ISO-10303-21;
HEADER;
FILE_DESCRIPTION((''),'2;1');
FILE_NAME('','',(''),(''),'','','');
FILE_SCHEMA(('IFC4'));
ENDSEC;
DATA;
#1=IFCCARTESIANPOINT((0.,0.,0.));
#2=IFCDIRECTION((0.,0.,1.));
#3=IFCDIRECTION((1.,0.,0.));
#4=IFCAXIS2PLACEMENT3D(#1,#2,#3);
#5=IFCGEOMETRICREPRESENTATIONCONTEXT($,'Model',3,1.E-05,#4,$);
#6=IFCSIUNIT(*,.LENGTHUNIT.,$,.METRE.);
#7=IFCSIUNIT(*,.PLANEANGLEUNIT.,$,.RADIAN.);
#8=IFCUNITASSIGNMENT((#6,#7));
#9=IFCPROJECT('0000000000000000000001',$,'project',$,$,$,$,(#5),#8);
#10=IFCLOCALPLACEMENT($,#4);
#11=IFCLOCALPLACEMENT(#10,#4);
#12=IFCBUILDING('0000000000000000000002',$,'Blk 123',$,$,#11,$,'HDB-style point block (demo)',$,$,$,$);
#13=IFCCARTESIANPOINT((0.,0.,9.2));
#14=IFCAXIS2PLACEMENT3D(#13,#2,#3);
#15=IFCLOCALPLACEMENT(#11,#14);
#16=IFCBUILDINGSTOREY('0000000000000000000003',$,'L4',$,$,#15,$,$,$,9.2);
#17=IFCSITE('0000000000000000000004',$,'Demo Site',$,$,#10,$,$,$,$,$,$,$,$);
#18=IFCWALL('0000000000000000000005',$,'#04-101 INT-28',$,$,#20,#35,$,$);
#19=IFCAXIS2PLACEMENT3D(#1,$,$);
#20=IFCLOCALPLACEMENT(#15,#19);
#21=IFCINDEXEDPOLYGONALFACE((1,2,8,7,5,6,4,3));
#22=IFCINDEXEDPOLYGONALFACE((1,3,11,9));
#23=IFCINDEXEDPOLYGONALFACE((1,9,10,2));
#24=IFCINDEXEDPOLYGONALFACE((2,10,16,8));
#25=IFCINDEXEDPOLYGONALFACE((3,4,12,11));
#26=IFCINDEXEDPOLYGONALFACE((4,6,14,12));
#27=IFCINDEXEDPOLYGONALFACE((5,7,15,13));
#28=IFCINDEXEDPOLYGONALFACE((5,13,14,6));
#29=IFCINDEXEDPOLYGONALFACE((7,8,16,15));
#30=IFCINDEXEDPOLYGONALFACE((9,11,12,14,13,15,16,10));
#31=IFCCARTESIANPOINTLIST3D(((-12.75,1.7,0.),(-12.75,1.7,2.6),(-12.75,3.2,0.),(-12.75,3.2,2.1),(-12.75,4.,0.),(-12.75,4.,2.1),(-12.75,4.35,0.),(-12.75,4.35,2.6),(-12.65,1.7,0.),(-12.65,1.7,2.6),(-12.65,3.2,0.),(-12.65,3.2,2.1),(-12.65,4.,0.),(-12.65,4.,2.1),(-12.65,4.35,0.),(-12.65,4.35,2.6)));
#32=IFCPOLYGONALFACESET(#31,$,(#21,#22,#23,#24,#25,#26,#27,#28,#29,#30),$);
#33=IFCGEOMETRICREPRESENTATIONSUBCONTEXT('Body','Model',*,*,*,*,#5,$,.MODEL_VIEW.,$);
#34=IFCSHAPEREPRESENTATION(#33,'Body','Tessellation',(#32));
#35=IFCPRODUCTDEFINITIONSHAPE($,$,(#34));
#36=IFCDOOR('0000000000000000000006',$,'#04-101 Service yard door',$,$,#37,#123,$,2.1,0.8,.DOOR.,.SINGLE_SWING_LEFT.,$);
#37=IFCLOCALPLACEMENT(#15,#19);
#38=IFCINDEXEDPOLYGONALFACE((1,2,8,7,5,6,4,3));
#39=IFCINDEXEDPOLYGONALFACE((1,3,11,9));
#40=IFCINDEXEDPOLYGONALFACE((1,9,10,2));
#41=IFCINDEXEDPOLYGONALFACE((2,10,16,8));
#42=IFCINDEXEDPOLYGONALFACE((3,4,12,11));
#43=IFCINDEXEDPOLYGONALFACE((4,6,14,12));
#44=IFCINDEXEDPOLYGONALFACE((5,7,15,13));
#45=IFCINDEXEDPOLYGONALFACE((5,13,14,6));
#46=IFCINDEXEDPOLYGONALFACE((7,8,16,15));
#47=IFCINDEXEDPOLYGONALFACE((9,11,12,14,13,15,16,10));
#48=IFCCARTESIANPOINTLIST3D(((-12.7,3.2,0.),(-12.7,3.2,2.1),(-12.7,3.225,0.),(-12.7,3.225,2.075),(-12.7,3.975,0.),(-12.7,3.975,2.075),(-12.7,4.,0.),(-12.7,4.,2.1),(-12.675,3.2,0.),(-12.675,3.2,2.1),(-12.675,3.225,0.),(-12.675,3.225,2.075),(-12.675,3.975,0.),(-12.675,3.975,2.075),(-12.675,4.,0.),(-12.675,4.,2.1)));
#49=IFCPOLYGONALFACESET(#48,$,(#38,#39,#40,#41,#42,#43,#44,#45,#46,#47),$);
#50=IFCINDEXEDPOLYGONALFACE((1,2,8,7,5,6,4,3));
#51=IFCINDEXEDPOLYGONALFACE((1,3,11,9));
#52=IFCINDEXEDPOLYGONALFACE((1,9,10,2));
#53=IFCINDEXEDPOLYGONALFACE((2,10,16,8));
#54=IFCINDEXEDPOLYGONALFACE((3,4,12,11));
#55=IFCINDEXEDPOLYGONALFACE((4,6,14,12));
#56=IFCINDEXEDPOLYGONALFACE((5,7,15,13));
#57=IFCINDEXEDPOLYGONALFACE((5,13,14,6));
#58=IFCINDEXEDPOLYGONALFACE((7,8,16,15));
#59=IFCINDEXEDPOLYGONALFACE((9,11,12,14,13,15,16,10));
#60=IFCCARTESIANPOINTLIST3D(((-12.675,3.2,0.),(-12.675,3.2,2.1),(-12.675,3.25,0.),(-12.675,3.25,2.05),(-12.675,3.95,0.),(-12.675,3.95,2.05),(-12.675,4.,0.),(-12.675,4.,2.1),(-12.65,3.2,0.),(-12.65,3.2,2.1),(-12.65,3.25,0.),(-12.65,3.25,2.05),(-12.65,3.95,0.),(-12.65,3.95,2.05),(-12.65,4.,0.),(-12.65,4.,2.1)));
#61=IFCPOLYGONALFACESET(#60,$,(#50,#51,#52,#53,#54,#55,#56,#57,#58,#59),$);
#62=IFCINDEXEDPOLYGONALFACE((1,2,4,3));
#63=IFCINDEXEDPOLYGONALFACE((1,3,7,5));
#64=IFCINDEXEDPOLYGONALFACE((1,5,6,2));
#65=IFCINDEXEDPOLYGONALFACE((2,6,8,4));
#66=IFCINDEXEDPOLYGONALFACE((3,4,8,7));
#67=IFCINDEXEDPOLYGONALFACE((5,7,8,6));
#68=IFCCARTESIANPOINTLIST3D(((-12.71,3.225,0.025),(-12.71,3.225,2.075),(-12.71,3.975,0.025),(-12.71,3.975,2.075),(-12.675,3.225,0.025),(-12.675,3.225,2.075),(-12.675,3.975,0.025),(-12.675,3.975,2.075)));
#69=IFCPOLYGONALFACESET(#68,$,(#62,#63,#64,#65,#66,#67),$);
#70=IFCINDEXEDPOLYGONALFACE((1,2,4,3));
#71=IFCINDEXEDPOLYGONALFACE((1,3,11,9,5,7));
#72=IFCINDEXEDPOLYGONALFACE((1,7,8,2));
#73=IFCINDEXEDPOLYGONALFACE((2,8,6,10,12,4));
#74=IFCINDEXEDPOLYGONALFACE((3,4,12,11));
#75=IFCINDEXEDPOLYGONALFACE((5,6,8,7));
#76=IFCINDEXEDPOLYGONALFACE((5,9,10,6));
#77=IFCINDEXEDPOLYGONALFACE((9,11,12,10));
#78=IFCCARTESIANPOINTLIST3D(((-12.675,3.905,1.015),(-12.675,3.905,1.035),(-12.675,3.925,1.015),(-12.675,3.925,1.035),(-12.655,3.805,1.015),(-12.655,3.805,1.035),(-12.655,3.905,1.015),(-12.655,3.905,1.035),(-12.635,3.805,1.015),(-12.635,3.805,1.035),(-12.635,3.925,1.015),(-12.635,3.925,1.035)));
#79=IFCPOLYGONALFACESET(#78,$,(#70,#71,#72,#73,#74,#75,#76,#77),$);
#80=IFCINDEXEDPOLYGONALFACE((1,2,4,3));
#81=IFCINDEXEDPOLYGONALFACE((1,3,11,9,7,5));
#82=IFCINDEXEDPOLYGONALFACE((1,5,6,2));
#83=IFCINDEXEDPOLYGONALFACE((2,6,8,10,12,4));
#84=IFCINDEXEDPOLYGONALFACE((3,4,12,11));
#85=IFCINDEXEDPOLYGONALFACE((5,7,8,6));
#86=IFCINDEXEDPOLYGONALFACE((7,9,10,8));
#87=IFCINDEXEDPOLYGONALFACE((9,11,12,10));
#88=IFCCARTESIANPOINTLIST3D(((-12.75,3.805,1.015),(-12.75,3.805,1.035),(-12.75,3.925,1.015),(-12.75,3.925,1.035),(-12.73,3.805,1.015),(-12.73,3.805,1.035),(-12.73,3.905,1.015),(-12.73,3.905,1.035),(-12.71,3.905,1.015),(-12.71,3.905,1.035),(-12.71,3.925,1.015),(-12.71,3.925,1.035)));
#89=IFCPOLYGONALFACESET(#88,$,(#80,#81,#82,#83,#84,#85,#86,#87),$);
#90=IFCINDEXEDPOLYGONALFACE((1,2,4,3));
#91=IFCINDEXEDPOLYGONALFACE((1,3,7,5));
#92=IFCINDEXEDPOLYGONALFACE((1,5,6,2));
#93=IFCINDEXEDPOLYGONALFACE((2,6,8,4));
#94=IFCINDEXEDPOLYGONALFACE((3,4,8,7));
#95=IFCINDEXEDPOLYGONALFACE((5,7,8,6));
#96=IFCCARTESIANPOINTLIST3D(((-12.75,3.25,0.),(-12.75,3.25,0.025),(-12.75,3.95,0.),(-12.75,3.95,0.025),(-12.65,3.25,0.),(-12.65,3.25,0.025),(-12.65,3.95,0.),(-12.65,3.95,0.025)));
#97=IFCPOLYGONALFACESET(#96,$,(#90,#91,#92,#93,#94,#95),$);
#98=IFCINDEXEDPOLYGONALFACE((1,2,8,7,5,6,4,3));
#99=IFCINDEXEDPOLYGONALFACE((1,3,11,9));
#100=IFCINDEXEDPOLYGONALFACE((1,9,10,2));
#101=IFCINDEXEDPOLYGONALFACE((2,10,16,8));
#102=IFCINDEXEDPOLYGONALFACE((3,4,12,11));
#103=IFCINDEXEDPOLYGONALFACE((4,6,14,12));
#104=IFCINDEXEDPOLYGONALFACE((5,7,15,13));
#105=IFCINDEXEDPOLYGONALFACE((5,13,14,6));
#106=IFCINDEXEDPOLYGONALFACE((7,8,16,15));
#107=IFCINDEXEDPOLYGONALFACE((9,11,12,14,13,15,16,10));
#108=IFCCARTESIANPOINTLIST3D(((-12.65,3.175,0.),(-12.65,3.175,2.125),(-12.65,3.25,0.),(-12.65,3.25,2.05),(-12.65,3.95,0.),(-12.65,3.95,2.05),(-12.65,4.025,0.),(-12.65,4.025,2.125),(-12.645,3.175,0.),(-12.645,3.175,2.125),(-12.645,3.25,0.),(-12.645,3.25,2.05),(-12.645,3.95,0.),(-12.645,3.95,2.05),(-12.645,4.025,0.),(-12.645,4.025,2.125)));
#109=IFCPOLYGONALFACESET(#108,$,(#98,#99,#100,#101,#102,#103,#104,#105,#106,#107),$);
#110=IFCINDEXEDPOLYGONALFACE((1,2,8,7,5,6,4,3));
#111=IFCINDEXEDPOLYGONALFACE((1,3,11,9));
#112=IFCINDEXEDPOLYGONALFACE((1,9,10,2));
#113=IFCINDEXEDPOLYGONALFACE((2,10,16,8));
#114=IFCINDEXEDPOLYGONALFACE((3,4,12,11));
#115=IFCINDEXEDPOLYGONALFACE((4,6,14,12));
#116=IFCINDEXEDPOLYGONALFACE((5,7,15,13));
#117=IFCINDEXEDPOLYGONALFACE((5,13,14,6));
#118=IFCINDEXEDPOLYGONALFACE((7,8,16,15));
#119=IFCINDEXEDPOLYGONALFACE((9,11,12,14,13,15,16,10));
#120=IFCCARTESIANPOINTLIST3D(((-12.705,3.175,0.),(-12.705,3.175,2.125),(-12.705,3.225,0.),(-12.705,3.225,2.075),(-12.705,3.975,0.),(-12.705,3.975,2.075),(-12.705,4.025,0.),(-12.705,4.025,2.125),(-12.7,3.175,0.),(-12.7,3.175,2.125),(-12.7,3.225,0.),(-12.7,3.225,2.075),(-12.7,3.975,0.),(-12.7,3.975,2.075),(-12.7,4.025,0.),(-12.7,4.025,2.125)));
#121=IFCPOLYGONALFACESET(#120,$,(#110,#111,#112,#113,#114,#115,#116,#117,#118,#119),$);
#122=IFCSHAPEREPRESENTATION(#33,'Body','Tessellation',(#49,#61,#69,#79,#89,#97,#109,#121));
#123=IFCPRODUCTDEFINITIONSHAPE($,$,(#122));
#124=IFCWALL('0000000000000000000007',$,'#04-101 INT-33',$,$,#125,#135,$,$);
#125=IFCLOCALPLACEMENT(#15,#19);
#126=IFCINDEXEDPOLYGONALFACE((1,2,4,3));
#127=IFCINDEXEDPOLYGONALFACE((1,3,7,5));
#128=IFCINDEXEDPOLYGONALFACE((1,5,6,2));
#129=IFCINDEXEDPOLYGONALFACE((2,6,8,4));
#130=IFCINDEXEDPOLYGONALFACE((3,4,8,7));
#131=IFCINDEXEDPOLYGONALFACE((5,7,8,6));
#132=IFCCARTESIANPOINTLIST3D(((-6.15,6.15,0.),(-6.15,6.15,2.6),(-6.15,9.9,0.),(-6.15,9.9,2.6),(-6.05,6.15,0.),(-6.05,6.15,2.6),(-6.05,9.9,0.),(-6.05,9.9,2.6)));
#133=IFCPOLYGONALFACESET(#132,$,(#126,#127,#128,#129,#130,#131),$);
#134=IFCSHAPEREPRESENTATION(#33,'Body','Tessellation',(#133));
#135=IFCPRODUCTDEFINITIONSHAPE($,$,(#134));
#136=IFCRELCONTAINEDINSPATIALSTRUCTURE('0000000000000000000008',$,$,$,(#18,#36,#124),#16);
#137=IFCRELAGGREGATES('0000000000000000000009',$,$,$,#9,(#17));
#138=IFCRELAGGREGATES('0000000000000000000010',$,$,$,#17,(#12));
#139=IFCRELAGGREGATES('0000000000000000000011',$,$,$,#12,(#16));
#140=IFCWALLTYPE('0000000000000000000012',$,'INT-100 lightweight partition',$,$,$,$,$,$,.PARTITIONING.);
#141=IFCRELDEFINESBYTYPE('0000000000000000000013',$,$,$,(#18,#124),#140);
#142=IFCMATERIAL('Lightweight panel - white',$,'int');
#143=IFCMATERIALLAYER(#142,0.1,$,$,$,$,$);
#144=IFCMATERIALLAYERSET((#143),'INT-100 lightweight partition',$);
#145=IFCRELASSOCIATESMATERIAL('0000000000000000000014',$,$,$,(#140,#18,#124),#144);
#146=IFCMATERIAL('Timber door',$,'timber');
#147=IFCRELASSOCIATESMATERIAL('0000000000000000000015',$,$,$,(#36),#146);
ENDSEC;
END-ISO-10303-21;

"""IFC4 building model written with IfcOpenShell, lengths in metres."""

from ifc_helpers import new_model, si_unit, frame, origin_with_axes, place, context, subcontext, project, spatial, line, indexed_curve, outline, extrude, material, layer, layer_set, layer_usage, type_object, element, fill, save


model = new_model("IFC4")

# Units and contexts
model_context = context("Model", 3, precision=1e-05, world=origin_with_axes())
body_context = subcontext(model_context, "Body", "Model", "MODEL_VIEW")
ifc_project = project(units=[si_unit("LENGTHUNIT", "METRE"), si_unit("PLANEANGLEUNIT", "RADIAN")], contexts=[model_context])

# Site, building, storey
site_placement = place(None, origin_with_axes())
site = spatial("IfcSite", under=ifc_project, at=site_placement, Name="Demo Site")
building_placement = place(site_placement, origin_with_axes())
building = spatial("IfcBuilding", under=site, at=building_placement, Name="Blk 123", LongName="HDB-style point block (demo)")
storey_placement = place(building_placement, frame((0.0, 0.0, 9.2), z_axis=(0.0, 0.0, 1.0), x_axis=(1.0, 0.0, 0.0)))
storey = spatial("IfcBuildingStorey", under=building, at=storey_placement, Name="L4", Elevation=9.2)

# Shared definitions
ifc_material_1 = material(Name="Timber door", Category="timber")

# Shared definitions
ifc_material_2 = material(Name="Lightweight panel - white", Category="int")
ifc_layer_1 = layer(ifc_material_2, 0.1)
ifc_layer_set_1 = layer_set([ifc_layer_1], Name="INT-100 lightweight partition")
ifc_layer_usage_1 = layer_usage(ifc_layer_set_1, "AXIS2", "POSITIVE", -0.05)
wall_type_1 = type_object("IfcWallType", Name="INT-100 lightweight partition", PredefinedType="PARTITIONING", material=ifc_layer_set_1)

# Wall, opening, door
wall_1_placement = place(storey_placement, frame((-12.7, 1.7, 0.0), z_axis=(0.0, 0.0, 1.0), x_axis=(0.0, 1.0, 0.0)))
wall_1 = element("IfcWall", 1, at=wall_1_placement, inside=storey, type_object=wall_type_1, material=ifc_layer_usage_1, Name="#04-101 INT-28", context=body_context, shape_type="SweptSolid", body=[
    extrude(outline(indexed_curve([(0.0, 0.0), (0.0, 0.1), (2.65, 0.1), (2.65, 0.0), (0.0, 0.0)], self_intersect=False)), frame((0.0, -0.05, 0.0), z_axis=(0.0, 0.0, 1.0), x_axis=(1.0, 0.0, 0.0)), (0.0, 0.0, 1.0), 2.6),
])
opening_1_placement = place(wall_1_placement, frame((1.5, -0.15, 0.0), z_axis=(0.0, 0.0, 1.0), x_axis=(1.0, 0.0, 0.0)))
opening_1 = element("IfcOpeningElement", 2, at=opening_1_placement, cuts=wall_1, context=body_context, shape_type="SweptSolid", body=[
    extrude(outline(indexed_curve([(0.0, 0.0), (0.0, 0.3), (0.8, 0.3), (0.8, 0.0), (0.0, 0.0)], self_intersect=False)), origin_with_axes(), (0.0, 0.0, 1.0), 2.1),
])
door_1_placement = place(opening_1_placement, frame((0.0, 0.1, 0.0), z_axis=(0.0, 0.0, 1.0), x_axis=(1.0, 0.0, 0.0)))
door_1 = element("IfcDoor", 3, at=door_1_placement, inside=storey, material=ifc_material_1, Name="#04-101 Service yard door", OperationType="SINGLE_SWING_LEFT", OverallHeight=2.1, OverallWidth=0.8, PredefinedType="DOOR", context=body_context, shape_type="SweptSolid", body=[
    extrude(outline(indexed_curve([(0.0, 0.0), (0.0, 2.1), (0.8, 2.1), (0.8, 0.0), (0.775, 0.0), (0.775, 2.075), (0.025, 2.075), (0.025, 0.0)], segments=[line(1, 2, 3, 4, 5, 6, 7, 8, 1)])), frame((0.0, 0.025, 0.0), z_axis=(0.0, -1.0, 0.0), x_axis=(1.0, 0.0, 0.0)), (0.0, 0.0, -1.0), 0.025),
    extrude(outline(indexed_curve([(0.0, 0.0), (0.0, 2.1), (0.8, 2.1), (0.8, 0.0), (0.75, 0.0), (0.75, 2.05), (0.05, 2.05), (0.05, 0.0)], segments=[line(1, 2, 3, 4, 5, 6, 7, 8, 1)])), frame((0.0, 0.0, 0.0), z_axis=(0.0, -1.0, 0.0), x_axis=(1.0, 0.0, 0.0)), (0.0, 0.0, -1.0), 0.025),
    extrude(outline(indexed_curve([(0.0, 0.0), (0.75, 0.0), (0.75, 0.035), (0.0, 0.035)], segments=[line(1, 2, 3, 4, 1)])), frame((0.025, 0.025, 0.025), z_axis=(0.0, 0.0, 1.0), x_axis=(1.0, 0.0, 0.0)), (0.0, 0.0, 1.0), 2.05),
    extrude(outline(indexed_curve([(0.0, 0.0), (0.0, -0.04), (-0.12, -0.04), (-0.12, -0.02), (-0.02, -0.02), (-0.02, 0.0)], segments=[line(1, 2, 3, 4, 5, 6, 1)])), frame((0.725, 0.025, 1.015), z_axis=(0.0, 0.0, 1.0), x_axis=(1.0, 0.0, 0.0)), (0.0, 0.0, 1.0), 0.02),
    extrude(outline(indexed_curve([(0.0, 0.0), (0.0, 0.04), (-0.12, 0.04), (-0.12, 0.02), (-0.02, 0.02), (-0.02, 0.0)], segments=[line(1, 2, 3, 4, 5, 6, 1)])), frame((0.725, 0.06, 1.015), z_axis=(0.0, 0.0, 1.0), x_axis=(1.0, 0.0, 0.0)), (0.0, 0.0, 1.0), 0.02),
    extrude(outline(indexed_curve([(0.0, 0.0), (0.7, 0.0), (0.7, 0.1), (0.0, 0.1)], segments=[line(1, 2, 3, 4, 1)])), frame((0.05, 0.0, 0.0), z_axis=(0.0, 0.0, 1.0), x_axis=(1.0, 0.0, 0.0)), (0.0, 0.0, 1.0), 0.025),
    extrude(outline(indexed_curve([(0.0, 0.0), (0.0, 2.125), (0.85, 2.125), (0.85, 0.0), (0.775, 0.0), (0.775, 2.05), (0.075, 2.05), (0.075, 0.0)], segments=[line(1, 2, 3, 4, 5, 6, 7, 8, 1)])), frame((-0.025, -0.005, 0.0), z_axis=(0.0, -1.0, 0.0), x_axis=(1.0, 0.0, 0.0)), (0.0, 0.0, -1.0), 0.005),
    extrude(outline(indexed_curve([(0.0, 0.0), (0.0, 2.125), (0.85, 2.125), (0.85, 0.0), (0.8, 0.0), (0.8, 2.075), (0.05, 2.075), (0.05, 0.0)], segments=[line(1, 2, 3, 4, 5, 6, 7, 8, 1)])), frame((-0.025, 0.05, 0.0), z_axis=(0.0, -1.0, 0.0), x_axis=(1.0, 0.0, 0.0)), (0.0, 0.0, -1.0), 0.005),
])
fill(opening_1, door_1)

# Wall
wall_2_placement = place(storey_placement, frame((-6.1, 6.15, 0.0), z_axis=(0.0, 0.0, 1.0), x_axis=(0.0, 1.0, 0.0)))
element("IfcWall", 4, at=wall_2_placement, inside=storey, type_object=wall_type_1, material=ifc_layer_usage_1, Name="#04-101 INT-33", context=body_context, shape_type="SweptSolid", body=[
    extrude(outline(indexed_curve([(0.0, 0.0), (0.0, 0.1), (3.75, 0.1), (3.75, 0.0), (0.0, 0.0)], self_intersect=False)), frame((0.0, -0.05, 0.0), z_axis=(0.0, 0.0, 1.0), x_axis=(1.0, 0.0, 0.0)), (0.0, 0.0, 1.0), 2.6),
])

save(model, "model.ifc")
